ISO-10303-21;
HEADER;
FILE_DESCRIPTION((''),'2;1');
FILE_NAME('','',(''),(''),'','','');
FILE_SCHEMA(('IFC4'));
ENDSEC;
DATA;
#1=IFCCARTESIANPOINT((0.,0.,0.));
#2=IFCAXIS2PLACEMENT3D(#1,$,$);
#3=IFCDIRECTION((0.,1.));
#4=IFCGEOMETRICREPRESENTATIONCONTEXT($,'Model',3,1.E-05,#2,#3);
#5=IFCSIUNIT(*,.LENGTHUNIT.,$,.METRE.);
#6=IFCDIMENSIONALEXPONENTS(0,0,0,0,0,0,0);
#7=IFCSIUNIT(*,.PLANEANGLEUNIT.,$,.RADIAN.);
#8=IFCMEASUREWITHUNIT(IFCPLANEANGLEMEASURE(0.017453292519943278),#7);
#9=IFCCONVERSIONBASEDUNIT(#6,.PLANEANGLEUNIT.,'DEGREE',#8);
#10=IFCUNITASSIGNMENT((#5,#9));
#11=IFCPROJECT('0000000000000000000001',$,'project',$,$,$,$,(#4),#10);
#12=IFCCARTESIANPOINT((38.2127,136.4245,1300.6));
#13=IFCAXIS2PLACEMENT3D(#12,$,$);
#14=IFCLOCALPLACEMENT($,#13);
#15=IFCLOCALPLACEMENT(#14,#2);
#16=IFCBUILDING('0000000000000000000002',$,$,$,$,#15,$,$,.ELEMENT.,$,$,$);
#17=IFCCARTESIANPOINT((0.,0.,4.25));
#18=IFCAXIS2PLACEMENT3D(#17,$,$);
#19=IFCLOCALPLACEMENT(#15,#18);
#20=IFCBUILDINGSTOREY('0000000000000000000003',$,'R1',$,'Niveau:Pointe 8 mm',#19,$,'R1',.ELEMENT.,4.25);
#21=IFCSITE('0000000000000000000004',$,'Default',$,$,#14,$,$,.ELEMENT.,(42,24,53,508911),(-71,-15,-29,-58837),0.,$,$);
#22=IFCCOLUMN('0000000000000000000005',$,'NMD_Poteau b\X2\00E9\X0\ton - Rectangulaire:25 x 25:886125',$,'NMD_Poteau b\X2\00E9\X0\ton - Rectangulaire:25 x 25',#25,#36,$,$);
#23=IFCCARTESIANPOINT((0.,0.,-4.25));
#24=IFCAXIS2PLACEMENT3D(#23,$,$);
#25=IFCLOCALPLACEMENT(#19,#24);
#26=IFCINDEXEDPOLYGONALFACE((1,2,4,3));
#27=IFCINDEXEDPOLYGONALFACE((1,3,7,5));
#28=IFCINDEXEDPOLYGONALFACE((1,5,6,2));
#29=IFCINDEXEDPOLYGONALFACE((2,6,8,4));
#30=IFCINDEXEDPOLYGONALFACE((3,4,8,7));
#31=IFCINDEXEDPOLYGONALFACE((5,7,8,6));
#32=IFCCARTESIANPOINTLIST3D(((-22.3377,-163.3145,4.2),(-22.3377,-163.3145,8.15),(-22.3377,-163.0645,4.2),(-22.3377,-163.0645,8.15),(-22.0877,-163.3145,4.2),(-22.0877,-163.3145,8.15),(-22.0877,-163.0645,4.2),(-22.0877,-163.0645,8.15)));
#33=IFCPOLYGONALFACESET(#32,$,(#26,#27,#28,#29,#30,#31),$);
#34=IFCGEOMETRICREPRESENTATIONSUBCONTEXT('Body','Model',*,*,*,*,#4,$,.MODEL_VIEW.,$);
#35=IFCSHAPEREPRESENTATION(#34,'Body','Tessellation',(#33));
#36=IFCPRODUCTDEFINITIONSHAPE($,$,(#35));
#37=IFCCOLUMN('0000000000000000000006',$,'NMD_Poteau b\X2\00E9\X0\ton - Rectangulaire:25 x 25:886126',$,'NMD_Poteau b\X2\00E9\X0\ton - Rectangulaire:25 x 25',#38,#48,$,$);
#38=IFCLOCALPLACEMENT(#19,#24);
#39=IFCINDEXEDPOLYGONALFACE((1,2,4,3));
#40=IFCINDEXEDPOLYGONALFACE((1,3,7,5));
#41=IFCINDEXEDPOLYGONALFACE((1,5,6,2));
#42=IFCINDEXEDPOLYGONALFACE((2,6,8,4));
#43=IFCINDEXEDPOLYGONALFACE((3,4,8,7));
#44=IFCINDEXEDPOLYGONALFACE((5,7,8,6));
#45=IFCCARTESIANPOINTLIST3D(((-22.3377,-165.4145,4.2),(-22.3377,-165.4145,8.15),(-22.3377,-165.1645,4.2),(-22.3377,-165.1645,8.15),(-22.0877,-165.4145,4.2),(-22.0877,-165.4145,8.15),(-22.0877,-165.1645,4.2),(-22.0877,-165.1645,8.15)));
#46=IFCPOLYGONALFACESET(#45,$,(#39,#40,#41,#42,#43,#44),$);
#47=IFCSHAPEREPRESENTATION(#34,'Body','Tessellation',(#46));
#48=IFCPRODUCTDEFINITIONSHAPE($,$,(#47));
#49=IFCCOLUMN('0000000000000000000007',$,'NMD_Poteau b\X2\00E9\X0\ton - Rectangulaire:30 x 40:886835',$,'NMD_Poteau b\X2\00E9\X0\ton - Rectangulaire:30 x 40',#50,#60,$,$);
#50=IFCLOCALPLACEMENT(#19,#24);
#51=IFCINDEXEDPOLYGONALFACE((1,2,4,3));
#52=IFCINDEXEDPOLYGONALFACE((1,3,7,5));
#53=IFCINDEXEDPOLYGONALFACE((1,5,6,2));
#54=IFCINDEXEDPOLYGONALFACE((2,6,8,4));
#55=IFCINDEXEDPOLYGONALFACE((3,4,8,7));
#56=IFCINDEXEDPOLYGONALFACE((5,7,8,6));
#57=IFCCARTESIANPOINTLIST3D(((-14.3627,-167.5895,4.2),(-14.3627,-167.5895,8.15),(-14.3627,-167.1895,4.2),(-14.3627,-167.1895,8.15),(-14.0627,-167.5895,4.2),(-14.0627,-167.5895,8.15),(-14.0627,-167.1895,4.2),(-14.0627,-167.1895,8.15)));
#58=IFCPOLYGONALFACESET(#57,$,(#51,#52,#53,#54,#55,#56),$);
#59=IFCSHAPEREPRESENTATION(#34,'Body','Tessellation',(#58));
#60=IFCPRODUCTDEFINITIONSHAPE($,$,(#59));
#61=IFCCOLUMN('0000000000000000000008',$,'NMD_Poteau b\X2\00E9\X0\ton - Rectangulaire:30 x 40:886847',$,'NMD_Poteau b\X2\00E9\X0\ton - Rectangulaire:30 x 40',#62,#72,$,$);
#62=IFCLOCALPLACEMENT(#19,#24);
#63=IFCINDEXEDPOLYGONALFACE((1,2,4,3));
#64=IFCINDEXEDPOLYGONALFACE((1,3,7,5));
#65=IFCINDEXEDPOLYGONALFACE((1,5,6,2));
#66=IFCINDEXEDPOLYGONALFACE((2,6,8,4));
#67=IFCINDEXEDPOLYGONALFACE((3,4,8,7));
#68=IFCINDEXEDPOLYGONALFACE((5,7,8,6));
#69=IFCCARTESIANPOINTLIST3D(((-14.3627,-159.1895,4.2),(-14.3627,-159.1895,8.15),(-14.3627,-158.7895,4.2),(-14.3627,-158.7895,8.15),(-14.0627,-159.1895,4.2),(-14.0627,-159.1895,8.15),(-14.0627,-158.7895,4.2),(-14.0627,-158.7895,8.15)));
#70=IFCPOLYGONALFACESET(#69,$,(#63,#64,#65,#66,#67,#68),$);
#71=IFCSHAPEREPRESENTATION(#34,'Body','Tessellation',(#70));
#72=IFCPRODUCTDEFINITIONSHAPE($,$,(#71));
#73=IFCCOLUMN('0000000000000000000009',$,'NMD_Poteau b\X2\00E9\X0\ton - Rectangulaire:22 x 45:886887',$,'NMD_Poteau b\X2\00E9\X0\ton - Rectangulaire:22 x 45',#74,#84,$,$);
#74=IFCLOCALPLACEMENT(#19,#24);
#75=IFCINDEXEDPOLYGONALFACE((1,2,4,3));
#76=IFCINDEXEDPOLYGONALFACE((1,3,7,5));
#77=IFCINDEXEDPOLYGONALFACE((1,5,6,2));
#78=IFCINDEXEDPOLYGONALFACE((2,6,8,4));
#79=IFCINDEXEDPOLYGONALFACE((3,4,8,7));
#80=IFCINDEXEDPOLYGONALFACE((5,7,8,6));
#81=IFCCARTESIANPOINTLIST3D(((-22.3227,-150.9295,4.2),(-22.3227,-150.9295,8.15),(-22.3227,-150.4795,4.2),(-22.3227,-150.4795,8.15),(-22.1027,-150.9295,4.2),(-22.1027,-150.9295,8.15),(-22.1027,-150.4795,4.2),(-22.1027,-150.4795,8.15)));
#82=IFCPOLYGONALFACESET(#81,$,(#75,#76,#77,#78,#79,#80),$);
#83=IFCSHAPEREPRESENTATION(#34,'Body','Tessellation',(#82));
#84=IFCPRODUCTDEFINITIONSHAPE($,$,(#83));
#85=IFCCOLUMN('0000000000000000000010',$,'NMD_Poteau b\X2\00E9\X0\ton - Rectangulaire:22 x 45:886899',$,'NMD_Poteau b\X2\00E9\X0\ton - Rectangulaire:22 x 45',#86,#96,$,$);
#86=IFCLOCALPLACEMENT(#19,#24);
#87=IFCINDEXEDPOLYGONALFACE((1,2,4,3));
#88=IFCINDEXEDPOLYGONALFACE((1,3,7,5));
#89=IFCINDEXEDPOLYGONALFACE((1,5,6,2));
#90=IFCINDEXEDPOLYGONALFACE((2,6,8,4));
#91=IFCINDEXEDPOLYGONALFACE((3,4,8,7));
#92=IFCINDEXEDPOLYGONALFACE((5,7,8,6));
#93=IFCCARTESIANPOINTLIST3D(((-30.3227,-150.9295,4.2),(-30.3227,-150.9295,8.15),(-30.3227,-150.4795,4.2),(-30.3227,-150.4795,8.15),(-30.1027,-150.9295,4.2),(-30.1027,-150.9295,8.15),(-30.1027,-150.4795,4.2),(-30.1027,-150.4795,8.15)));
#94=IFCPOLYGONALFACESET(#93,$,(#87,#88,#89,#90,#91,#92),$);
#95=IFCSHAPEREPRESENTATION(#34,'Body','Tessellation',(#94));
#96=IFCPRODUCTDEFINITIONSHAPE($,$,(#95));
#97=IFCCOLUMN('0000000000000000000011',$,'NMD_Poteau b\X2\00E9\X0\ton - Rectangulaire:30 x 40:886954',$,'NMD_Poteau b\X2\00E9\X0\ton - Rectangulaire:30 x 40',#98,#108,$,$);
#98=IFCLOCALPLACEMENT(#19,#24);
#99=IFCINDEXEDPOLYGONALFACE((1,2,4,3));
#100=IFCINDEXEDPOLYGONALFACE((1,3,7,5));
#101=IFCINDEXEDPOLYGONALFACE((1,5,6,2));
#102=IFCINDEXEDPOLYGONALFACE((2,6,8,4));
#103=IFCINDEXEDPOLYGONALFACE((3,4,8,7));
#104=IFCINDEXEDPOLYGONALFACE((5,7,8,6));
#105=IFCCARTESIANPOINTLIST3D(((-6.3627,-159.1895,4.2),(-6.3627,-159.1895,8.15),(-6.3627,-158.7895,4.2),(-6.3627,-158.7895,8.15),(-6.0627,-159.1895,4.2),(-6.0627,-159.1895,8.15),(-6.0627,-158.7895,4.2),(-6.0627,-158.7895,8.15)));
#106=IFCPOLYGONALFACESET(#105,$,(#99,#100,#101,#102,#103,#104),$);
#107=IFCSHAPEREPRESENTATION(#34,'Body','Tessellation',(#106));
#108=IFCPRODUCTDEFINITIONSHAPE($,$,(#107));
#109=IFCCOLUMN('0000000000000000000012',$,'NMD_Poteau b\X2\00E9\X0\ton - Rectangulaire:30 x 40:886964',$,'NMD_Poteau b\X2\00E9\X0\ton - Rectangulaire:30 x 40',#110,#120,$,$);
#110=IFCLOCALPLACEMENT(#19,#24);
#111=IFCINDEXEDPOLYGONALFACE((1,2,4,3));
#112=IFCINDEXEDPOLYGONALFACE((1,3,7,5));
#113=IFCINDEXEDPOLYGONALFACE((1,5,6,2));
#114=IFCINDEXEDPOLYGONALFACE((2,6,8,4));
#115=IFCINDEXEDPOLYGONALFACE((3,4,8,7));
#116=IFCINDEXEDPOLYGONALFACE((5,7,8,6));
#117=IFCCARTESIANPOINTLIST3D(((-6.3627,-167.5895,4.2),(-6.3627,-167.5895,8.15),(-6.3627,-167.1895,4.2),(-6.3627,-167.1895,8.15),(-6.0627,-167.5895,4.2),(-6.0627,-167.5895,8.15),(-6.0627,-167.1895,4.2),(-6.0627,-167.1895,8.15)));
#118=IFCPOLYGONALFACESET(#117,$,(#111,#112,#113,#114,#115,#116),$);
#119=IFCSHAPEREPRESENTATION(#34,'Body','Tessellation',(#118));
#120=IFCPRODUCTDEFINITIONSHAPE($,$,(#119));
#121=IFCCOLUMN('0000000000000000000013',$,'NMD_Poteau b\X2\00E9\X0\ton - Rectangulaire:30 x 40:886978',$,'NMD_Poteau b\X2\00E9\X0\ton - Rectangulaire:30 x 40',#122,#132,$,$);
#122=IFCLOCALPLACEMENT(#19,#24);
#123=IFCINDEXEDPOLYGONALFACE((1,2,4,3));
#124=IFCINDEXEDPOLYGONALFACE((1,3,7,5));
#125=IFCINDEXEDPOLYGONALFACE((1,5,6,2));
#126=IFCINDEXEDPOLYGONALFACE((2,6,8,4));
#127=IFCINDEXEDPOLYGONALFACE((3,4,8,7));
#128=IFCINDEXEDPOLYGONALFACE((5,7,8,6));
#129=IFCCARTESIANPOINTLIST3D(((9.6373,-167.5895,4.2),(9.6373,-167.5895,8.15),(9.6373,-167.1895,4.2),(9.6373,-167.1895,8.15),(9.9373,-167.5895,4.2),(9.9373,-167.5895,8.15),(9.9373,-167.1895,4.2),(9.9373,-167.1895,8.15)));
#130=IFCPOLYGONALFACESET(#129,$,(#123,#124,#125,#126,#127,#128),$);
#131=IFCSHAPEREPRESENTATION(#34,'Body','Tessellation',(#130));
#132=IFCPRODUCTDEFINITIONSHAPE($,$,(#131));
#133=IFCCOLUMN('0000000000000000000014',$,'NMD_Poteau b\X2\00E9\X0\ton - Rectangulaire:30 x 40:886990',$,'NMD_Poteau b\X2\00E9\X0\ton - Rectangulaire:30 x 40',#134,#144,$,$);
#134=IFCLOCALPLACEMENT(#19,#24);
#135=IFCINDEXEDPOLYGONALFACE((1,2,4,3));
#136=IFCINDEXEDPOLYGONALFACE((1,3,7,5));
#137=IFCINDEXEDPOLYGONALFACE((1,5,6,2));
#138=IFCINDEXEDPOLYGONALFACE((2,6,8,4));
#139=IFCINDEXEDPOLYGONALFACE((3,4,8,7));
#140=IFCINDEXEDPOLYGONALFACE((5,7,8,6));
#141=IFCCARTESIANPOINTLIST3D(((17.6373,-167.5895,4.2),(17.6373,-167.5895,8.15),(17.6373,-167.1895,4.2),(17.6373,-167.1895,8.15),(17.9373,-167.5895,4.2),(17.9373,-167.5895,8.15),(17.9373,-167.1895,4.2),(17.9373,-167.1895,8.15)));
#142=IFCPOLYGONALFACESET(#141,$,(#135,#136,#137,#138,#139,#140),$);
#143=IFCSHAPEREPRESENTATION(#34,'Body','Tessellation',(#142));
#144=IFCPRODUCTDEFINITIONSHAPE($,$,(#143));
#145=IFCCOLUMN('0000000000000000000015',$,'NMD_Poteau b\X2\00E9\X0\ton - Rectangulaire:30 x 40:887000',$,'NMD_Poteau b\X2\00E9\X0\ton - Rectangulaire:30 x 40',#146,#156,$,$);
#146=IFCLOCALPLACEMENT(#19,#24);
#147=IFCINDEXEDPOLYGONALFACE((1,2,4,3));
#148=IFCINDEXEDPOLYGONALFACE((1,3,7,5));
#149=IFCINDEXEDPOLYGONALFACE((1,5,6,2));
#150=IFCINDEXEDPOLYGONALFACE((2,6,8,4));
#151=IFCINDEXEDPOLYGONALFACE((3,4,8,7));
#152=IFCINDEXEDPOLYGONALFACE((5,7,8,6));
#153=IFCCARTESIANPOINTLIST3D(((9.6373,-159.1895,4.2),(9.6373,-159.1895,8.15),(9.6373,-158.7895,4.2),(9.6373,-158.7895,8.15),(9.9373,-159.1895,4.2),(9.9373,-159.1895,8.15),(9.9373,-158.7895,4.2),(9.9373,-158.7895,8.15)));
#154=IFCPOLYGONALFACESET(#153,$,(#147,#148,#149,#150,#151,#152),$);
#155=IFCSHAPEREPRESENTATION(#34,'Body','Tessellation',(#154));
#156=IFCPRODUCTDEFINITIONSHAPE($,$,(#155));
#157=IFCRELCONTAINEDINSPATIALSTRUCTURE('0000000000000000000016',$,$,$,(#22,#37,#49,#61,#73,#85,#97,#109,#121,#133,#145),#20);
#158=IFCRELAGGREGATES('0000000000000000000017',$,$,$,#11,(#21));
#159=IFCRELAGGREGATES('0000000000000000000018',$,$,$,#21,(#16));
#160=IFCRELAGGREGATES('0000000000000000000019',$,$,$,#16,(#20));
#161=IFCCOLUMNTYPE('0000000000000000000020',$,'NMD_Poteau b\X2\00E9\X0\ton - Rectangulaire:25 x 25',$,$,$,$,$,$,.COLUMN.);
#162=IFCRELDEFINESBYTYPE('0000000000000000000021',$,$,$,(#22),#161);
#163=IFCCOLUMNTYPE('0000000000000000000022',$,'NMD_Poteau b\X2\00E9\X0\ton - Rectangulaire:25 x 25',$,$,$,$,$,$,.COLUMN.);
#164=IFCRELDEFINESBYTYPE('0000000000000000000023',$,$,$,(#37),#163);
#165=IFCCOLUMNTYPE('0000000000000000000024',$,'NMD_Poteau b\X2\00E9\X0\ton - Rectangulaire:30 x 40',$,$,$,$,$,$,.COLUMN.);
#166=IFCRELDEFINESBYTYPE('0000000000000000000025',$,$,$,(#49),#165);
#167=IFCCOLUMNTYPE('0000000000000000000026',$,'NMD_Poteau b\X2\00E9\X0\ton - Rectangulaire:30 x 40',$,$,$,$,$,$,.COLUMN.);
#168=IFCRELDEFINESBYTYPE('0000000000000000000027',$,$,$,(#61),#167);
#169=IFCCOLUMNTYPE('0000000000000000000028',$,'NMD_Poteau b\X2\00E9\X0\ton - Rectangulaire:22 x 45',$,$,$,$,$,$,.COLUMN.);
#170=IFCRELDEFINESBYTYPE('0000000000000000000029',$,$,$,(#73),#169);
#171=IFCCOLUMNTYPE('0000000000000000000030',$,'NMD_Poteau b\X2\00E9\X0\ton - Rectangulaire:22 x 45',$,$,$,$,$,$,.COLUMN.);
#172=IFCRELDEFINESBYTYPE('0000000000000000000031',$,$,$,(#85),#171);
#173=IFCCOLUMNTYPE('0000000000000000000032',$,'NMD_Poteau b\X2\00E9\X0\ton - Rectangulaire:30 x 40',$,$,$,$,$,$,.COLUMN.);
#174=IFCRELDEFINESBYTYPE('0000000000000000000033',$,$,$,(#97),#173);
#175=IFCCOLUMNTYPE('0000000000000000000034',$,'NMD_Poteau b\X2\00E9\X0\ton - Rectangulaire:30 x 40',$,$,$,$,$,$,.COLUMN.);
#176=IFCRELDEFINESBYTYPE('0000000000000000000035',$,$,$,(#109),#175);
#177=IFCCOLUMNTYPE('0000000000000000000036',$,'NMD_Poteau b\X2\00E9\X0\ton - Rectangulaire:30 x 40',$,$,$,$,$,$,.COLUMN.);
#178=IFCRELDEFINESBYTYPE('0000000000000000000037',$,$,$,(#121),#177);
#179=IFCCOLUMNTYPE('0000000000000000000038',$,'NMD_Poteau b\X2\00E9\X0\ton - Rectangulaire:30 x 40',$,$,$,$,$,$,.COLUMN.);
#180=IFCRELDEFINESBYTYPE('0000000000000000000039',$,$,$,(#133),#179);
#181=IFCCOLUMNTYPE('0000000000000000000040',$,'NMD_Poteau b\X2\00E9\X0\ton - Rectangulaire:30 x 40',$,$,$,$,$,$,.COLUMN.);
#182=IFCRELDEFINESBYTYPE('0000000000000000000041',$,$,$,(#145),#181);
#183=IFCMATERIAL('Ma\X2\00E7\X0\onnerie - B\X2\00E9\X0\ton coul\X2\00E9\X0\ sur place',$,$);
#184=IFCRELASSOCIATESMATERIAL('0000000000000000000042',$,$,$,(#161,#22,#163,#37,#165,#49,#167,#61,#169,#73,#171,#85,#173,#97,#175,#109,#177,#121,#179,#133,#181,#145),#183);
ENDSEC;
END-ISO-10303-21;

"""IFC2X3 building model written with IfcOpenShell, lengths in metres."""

from ifc_helpers import new_model, entity, si_unit, converted_unit, direction, frame, frame_2d, origin, origin_2d_with_axis, place, context, subcontext, project, spatial, rectangle, extrude, source, transform, mapped, material, type_object, type_shapes, element, save


model = new_model("IFC2X3")

# Units and contexts
model_context = context("Model", 3, precision=1e-05, world=origin(), true_north=direction((0.0, 1.0)))
body_context = subcontext(model_context, "Body", "Model", "MODEL_VIEW")
ifc_project = project(units=[si_unit("LENGTHUNIT", "METRE"), converted_unit("PLANEANGLEUNIT", "DEGREE", entity("IfcPlaneAngleMeasure", 0.017453292519943278), si_unit("PLANEANGLEUNIT", "RADIAN"), dimensions=[0, 0, 0, 0, 0, 0, 0])], contexts=[model_context])

# Site, building, storey
site_placement = place(None, frame((38.2127, 136.4245, 1300.6)))
site = spatial("IfcSite", under=ifc_project, at=site_placement, Name="Default", CompositionType="ELEMENT", RefLatitude=(42, 24, 53, 508911), RefLongitude=(-71, -15, -29, -58837), RefElevation=0.0)
building_placement = place(site_placement, origin())
building = spatial("IfcBuilding", under=site, at=building_placement, CompositionType="ELEMENT")
storey_placement = place(building_placement, frame((0.0, 0.0, 4.25)))
storey = spatial("IfcBuildingStorey", under=building, at=storey_placement, Name="R1", ObjectType="Niveau:Pointe 8 mm", LongName="R1", CompositionType="ELEMENT", Elevation=4.25)

# Columns
ifc_material = material(Name="Maçonnerie - Béton coulé sur place")
column_type_1 = type_object("IfcColumnType", Name="NMD_Poteau béton - Rectangulaire:25 x 25", PredefinedType="COLUMN", material=ifc_material)
shared_shape_1 = source(origin(), body_context, "Body", "SweptSolid", [
    extrude(rectangle(XDim=0.25, YDim=0.25, at=frame_2d((0.0, 0.0), x_axis=(1.0, 0.0))), frame((-22.2127, -163.1895, 4.2), z_axis=(0.0, 0.0, 1.0), x_axis=(0.0, 1.0, 0.0)), (0.0, 0.0, 1.0), 3.95),
])
type_shapes(column_type_1, [shared_shape_1])
column_1_placement = place(storey_placement, frame((0.0, 0.0, -4.25)))
element("IfcColumn", 1, at=column_1_placement, inside=storey, type_object=column_type_1, material=ifc_material, Name="NMD_Poteau béton - Rectangulaire:25 x 25:886125", ObjectType="NMD_Poteau béton - Rectangulaire:25 x 25", context=body_context, shape_type="MappedRepresentation", body=[
    mapped(shared_shape_1, transform((0.0, 0.0, 0.0), scale=1.0)),
])
column_type_2 = type_object("IfcColumnType", Name="NMD_Poteau béton - Rectangulaire:25 x 25", PredefinedType="COLUMN", material=ifc_material)
shared_shape_2 = source(origin(), body_context, "Body", "SweptSolid", [
    extrude(rectangle(XDim=0.25, YDim=0.25, at=frame_2d((0.0, 0.0), x_axis=(1.0, 0.0))), frame((-22.2127, -165.2895, 4.2), z_axis=(0.0, 0.0, 1.0), x_axis=(0.0, 1.0, 0.0)), (0.0, 0.0, 1.0), 3.95),
])
type_shapes(column_type_2, [shared_shape_2])
column_2_placement = place(storey_placement, frame((0.0, 0.0, -4.25)))
element("IfcColumn", 2, at=column_2_placement, inside=storey, type_object=column_type_2, material=ifc_material, Name="NMD_Poteau béton - Rectangulaire:25 x 25:886126", ObjectType="NMD_Poteau béton - Rectangulaire:25 x 25", context=body_context, shape_type="MappedRepresentation", body=[
    mapped(shared_shape_2, transform((0.0, 0.0, 0.0), scale=1.0)),
])
column_type_3 = type_object("IfcColumnType", Name="NMD_Poteau béton - Rectangulaire:30 x 40", PredefinedType="COLUMN", material=ifc_material)
shared_shape_3 = source(origin(), body_context, "Body", "SweptSolid", [
    extrude(rectangle(XDim=0.3, YDim=0.4, at=frame_2d((0.0, 0.0), x_axis=(1.0, 0.0))), frame((-14.2127, -167.3895, 4.2), z_axis=(0.0, 0.0, 1.0), x_axis=(-1.0, 0.0, 0.0)), (0.0, 0.0, 1.0), 3.95),
])
type_shapes(column_type_3, [shared_shape_3])
column_3_placement = place(storey_placement, frame((0.0, 0.0, -4.25)))
element("IfcColumn", 3, at=column_3_placement, inside=storey, type_object=column_type_3, material=ifc_material, Name="NMD_Poteau béton - Rectangulaire:30 x 40:886835", ObjectType="NMD_Poteau béton - Rectangulaire:30 x 40", context=body_context, shape_type="MappedRepresentation", body=[
    mapped(shared_shape_3, transform((0.0, 0.0, 0.0), scale=1.0)),
])
column_type_4 = type_object("IfcColumnType", Name="NMD_Poteau béton - Rectangulaire:30 x 40", PredefinedType="COLUMN", material=ifc_material)
shared_shape_4 = source(origin(), body_context, "Body", "SweptSolid", [
    extrude(rectangle(XDim=0.3, YDim=0.4, at=frame_2d((0.0, 0.0), x_axis=(1.0, 0.0))), frame((-14.2127, -158.9895, 4.2), z_axis=(0.0, 0.0, 1.0), x_axis=(-1.0, 0.0, 0.0)), (0.0, 0.0, 1.0), 3.95),
])
type_shapes(column_type_4, [shared_shape_4])
column_4_placement = place(storey_placement, frame((0.0, 0.0, -4.25)))
element("IfcColumn", 4, at=column_4_placement, inside=storey, type_object=column_type_4, material=ifc_material, Name="NMD_Poteau béton - Rectangulaire:30 x 40:886847", ObjectType="NMD_Poteau béton - Rectangulaire:30 x 40", context=body_context, shape_type="MappedRepresentation", body=[
    mapped(shared_shape_4, transform((0.0, 0.0, 0.0), scale=1.0)),
])
column_type_5 = type_object("IfcColumnType", Name="NMD_Poteau béton - Rectangulaire:22 x 45", PredefinedType="COLUMN", material=ifc_material)
shared_shape_5 = source(origin(), body_context, "Body", "SweptSolid", [
    extrude(rectangle(XDim=0.22, YDim=0.45, at=origin_2d_with_axis()), frame((-22.2127, -150.7045, 4.2)), (0.0, 0.0, 1.0), 3.95),
])
type_shapes(column_type_5, [shared_shape_5])
column_5_placement = place(storey_placement, frame((0.0, 0.0, -4.25)))
element("IfcColumn", 5, at=column_5_placement, inside=storey, type_object=column_type_5, material=ifc_material, Name="NMD_Poteau béton - Rectangulaire:22 x 45:886887", ObjectType="NMD_Poteau béton - Rectangulaire:22 x 45", context=body_context, shape_type="MappedRepresentation", body=[
    mapped(shared_shape_5, transform((0.0, 0.0, 0.0), scale=1.0)),
])
column_type_6 = type_object("IfcColumnType", Name="NMD_Poteau béton - Rectangulaire:22 x 45", PredefinedType="COLUMN", material=ifc_material)
shared_shape_6 = source(origin(), body_context, "Body", "SweptSolid", [
    extrude(rectangle(XDim=0.22, YDim=0.45, at=origin_2d_with_axis()), frame((-30.2127, -150.7045, 4.2)), (0.0, 0.0, 1.0), 3.95),
])
type_shapes(column_type_6, [shared_shape_6])
column_6_placement = place(storey_placement, frame((0.0, 0.0, -4.25)))
element("IfcColumn", 6, at=column_6_placement, inside=storey, type_object=column_type_6, material=ifc_material, Name="NMD_Poteau béton - Rectangulaire:22 x 45:886899", ObjectType="NMD_Poteau béton - Rectangulaire:22 x 45", context=body_context, shape_type="MappedRepresentation", body=[
    mapped(shared_shape_6, transform((0.0, 0.0, 0.0), scale=1.0)),
])
column_type_7 = type_object("IfcColumnType", Name="NMD_Poteau béton - Rectangulaire:30 x 40", PredefinedType="COLUMN", material=ifc_material)
shared_shape_7 = source(origin(), body_context, "Body", "SweptSolid", [
    extrude(rectangle(XDim=0.3, YDim=0.4, at=frame_2d((0.0, 0.0), x_axis=(1.0, 0.0))), frame((-6.2127, -158.9895, 4.2), z_axis=(0.0, 0.0, 1.0), x_axis=(-1.0, 0.0, 0.0)), (0.0, 0.0, 1.0), 3.95),
])
type_shapes(column_type_7, [shared_shape_7])
column_7_placement = place(storey_placement, frame((0.0, 0.0, -4.25)))
element("IfcColumn", 7, at=column_7_placement, inside=storey, type_object=column_type_7, material=ifc_material, Name="NMD_Poteau béton - Rectangulaire:30 x 40:886954", ObjectType="NMD_Poteau béton - Rectangulaire:30 x 40", context=body_context, shape_type="MappedRepresentation", body=[
    mapped(shared_shape_7, transform((0.0, 0.0, 0.0), scale=1.0)),
])
column_type_8 = type_object("IfcColumnType", Name="NMD_Poteau béton - Rectangulaire:30 x 40", PredefinedType="COLUMN", material=ifc_material)
shared_shape_8 = source(origin(), body_context, "Body", "SweptSolid", [
    extrude(rectangle(XDim=0.3, YDim=0.4, at=frame_2d((0.0, 0.0), x_axis=(1.0, 0.0))), frame((-6.2127, -167.3895, 4.2), z_axis=(0.0, 0.0, 1.0), x_axis=(-1.0, 0.0, 0.0)), (0.0, 0.0, 1.0), 3.95),
])
type_shapes(column_type_8, [shared_shape_8])
column_8_placement = place(storey_placement, frame((0.0, 0.0, -4.25)))
element("IfcColumn", 8, at=column_8_placement, inside=storey, type_object=column_type_8, material=ifc_material, Name="NMD_Poteau béton - Rectangulaire:30 x 40:886964", ObjectType="NMD_Poteau béton - Rectangulaire:30 x 40", context=body_context, shape_type="MappedRepresentation", body=[
    mapped(shared_shape_8, transform((0.0, 0.0, 0.0), scale=1.0)),
])
column_type_9 = type_object("IfcColumnType", Name="NMD_Poteau béton - Rectangulaire:30 x 40", PredefinedType="COLUMN", material=ifc_material)
shared_shape_9 = source(origin(), body_context, "Body", "SweptSolid", [
    extrude(rectangle(XDim=0.3, YDim=0.4, at=frame_2d((0.0, 0.0), x_axis=(1.0, 0.0))), frame((9.7873, -167.3895, 4.2), z_axis=(0.0, 0.0, 1.0), x_axis=(-1.0, 0.0, 0.0)), (0.0, 0.0, 1.0), 3.95),
])
type_shapes(column_type_9, [shared_shape_9])
column_9_placement = place(storey_placement, frame((0.0, 0.0, -4.25)))
element("IfcColumn", 9, at=column_9_placement, inside=storey, type_object=column_type_9, material=ifc_material, Name="NMD_Poteau béton - Rectangulaire:30 x 40:886978", ObjectType="NMD_Poteau béton - Rectangulaire:30 x 40", context=body_context, shape_type="MappedRepresentation", body=[
    mapped(shared_shape_9, transform((0.0, 0.0, 0.0), scale=1.0)),
])
column_type_10 = type_object("IfcColumnType", Name="NMD_Poteau béton - Rectangulaire:30 x 40", PredefinedType="COLUMN", material=ifc_material)
shared_shape_10 = source(origin(), body_context, "Body", "SweptSolid", [
    extrude(rectangle(XDim=0.3, YDim=0.4, at=frame_2d((0.0, 0.0), x_axis=(1.0, 0.0))), frame((17.7873, -167.3895, 4.2), z_axis=(0.0, 0.0, 1.0), x_axis=(-1.0, 0.0, 0.0)), (0.0, 0.0, 1.0), 3.95),
])
type_shapes(column_type_10, [shared_shape_10])
column_10_placement = place(storey_placement, frame((0.0, 0.0, -4.25)))
element("IfcColumn", 10, at=column_10_placement, inside=storey, type_object=column_type_10, material=ifc_material, Name="NMD_Poteau béton - Rectangulaire:30 x 40:886990", ObjectType="NMD_Poteau béton - Rectangulaire:30 x 40", context=body_context, shape_type="MappedRepresentation", body=[
    mapped(shared_shape_10, transform((0.0, 0.0, 0.0), scale=1.0)),
])
column_type_11 = type_object("IfcColumnType", Name="NMD_Poteau béton - Rectangulaire:30 x 40", PredefinedType="COLUMN", material=ifc_material)
shared_shape_11 = source(origin(), body_context, "Body", "SweptSolid", [
    extrude(rectangle(XDim=0.3, YDim=0.4, at=frame_2d((0.0, 0.0), x_axis=(1.0, 0.0))), frame((9.7873, -158.9895, 4.2), z_axis=(0.0, 0.0, 1.0), x_axis=(-1.0, 0.0, 0.0)), (0.0, 0.0, 1.0), 3.95),
])
type_shapes(column_type_11, [shared_shape_11])
column_11_placement = place(storey_placement, frame((0.0, 0.0, -4.25)))
element("IfcColumn", 11, at=column_11_placement, inside=storey, type_object=column_type_11, material=ifc_material, Name="NMD_Poteau béton - Rectangulaire:30 x 40:887000", ObjectType="NMD_Poteau béton - Rectangulaire:30 x 40", context=body_context, shape_type="MappedRepresentation", body=[
    mapped(shared_shape_11, transform((0.0, 0.0, 0.0), scale=1.0)),
])

save(model, "model.ifc")
